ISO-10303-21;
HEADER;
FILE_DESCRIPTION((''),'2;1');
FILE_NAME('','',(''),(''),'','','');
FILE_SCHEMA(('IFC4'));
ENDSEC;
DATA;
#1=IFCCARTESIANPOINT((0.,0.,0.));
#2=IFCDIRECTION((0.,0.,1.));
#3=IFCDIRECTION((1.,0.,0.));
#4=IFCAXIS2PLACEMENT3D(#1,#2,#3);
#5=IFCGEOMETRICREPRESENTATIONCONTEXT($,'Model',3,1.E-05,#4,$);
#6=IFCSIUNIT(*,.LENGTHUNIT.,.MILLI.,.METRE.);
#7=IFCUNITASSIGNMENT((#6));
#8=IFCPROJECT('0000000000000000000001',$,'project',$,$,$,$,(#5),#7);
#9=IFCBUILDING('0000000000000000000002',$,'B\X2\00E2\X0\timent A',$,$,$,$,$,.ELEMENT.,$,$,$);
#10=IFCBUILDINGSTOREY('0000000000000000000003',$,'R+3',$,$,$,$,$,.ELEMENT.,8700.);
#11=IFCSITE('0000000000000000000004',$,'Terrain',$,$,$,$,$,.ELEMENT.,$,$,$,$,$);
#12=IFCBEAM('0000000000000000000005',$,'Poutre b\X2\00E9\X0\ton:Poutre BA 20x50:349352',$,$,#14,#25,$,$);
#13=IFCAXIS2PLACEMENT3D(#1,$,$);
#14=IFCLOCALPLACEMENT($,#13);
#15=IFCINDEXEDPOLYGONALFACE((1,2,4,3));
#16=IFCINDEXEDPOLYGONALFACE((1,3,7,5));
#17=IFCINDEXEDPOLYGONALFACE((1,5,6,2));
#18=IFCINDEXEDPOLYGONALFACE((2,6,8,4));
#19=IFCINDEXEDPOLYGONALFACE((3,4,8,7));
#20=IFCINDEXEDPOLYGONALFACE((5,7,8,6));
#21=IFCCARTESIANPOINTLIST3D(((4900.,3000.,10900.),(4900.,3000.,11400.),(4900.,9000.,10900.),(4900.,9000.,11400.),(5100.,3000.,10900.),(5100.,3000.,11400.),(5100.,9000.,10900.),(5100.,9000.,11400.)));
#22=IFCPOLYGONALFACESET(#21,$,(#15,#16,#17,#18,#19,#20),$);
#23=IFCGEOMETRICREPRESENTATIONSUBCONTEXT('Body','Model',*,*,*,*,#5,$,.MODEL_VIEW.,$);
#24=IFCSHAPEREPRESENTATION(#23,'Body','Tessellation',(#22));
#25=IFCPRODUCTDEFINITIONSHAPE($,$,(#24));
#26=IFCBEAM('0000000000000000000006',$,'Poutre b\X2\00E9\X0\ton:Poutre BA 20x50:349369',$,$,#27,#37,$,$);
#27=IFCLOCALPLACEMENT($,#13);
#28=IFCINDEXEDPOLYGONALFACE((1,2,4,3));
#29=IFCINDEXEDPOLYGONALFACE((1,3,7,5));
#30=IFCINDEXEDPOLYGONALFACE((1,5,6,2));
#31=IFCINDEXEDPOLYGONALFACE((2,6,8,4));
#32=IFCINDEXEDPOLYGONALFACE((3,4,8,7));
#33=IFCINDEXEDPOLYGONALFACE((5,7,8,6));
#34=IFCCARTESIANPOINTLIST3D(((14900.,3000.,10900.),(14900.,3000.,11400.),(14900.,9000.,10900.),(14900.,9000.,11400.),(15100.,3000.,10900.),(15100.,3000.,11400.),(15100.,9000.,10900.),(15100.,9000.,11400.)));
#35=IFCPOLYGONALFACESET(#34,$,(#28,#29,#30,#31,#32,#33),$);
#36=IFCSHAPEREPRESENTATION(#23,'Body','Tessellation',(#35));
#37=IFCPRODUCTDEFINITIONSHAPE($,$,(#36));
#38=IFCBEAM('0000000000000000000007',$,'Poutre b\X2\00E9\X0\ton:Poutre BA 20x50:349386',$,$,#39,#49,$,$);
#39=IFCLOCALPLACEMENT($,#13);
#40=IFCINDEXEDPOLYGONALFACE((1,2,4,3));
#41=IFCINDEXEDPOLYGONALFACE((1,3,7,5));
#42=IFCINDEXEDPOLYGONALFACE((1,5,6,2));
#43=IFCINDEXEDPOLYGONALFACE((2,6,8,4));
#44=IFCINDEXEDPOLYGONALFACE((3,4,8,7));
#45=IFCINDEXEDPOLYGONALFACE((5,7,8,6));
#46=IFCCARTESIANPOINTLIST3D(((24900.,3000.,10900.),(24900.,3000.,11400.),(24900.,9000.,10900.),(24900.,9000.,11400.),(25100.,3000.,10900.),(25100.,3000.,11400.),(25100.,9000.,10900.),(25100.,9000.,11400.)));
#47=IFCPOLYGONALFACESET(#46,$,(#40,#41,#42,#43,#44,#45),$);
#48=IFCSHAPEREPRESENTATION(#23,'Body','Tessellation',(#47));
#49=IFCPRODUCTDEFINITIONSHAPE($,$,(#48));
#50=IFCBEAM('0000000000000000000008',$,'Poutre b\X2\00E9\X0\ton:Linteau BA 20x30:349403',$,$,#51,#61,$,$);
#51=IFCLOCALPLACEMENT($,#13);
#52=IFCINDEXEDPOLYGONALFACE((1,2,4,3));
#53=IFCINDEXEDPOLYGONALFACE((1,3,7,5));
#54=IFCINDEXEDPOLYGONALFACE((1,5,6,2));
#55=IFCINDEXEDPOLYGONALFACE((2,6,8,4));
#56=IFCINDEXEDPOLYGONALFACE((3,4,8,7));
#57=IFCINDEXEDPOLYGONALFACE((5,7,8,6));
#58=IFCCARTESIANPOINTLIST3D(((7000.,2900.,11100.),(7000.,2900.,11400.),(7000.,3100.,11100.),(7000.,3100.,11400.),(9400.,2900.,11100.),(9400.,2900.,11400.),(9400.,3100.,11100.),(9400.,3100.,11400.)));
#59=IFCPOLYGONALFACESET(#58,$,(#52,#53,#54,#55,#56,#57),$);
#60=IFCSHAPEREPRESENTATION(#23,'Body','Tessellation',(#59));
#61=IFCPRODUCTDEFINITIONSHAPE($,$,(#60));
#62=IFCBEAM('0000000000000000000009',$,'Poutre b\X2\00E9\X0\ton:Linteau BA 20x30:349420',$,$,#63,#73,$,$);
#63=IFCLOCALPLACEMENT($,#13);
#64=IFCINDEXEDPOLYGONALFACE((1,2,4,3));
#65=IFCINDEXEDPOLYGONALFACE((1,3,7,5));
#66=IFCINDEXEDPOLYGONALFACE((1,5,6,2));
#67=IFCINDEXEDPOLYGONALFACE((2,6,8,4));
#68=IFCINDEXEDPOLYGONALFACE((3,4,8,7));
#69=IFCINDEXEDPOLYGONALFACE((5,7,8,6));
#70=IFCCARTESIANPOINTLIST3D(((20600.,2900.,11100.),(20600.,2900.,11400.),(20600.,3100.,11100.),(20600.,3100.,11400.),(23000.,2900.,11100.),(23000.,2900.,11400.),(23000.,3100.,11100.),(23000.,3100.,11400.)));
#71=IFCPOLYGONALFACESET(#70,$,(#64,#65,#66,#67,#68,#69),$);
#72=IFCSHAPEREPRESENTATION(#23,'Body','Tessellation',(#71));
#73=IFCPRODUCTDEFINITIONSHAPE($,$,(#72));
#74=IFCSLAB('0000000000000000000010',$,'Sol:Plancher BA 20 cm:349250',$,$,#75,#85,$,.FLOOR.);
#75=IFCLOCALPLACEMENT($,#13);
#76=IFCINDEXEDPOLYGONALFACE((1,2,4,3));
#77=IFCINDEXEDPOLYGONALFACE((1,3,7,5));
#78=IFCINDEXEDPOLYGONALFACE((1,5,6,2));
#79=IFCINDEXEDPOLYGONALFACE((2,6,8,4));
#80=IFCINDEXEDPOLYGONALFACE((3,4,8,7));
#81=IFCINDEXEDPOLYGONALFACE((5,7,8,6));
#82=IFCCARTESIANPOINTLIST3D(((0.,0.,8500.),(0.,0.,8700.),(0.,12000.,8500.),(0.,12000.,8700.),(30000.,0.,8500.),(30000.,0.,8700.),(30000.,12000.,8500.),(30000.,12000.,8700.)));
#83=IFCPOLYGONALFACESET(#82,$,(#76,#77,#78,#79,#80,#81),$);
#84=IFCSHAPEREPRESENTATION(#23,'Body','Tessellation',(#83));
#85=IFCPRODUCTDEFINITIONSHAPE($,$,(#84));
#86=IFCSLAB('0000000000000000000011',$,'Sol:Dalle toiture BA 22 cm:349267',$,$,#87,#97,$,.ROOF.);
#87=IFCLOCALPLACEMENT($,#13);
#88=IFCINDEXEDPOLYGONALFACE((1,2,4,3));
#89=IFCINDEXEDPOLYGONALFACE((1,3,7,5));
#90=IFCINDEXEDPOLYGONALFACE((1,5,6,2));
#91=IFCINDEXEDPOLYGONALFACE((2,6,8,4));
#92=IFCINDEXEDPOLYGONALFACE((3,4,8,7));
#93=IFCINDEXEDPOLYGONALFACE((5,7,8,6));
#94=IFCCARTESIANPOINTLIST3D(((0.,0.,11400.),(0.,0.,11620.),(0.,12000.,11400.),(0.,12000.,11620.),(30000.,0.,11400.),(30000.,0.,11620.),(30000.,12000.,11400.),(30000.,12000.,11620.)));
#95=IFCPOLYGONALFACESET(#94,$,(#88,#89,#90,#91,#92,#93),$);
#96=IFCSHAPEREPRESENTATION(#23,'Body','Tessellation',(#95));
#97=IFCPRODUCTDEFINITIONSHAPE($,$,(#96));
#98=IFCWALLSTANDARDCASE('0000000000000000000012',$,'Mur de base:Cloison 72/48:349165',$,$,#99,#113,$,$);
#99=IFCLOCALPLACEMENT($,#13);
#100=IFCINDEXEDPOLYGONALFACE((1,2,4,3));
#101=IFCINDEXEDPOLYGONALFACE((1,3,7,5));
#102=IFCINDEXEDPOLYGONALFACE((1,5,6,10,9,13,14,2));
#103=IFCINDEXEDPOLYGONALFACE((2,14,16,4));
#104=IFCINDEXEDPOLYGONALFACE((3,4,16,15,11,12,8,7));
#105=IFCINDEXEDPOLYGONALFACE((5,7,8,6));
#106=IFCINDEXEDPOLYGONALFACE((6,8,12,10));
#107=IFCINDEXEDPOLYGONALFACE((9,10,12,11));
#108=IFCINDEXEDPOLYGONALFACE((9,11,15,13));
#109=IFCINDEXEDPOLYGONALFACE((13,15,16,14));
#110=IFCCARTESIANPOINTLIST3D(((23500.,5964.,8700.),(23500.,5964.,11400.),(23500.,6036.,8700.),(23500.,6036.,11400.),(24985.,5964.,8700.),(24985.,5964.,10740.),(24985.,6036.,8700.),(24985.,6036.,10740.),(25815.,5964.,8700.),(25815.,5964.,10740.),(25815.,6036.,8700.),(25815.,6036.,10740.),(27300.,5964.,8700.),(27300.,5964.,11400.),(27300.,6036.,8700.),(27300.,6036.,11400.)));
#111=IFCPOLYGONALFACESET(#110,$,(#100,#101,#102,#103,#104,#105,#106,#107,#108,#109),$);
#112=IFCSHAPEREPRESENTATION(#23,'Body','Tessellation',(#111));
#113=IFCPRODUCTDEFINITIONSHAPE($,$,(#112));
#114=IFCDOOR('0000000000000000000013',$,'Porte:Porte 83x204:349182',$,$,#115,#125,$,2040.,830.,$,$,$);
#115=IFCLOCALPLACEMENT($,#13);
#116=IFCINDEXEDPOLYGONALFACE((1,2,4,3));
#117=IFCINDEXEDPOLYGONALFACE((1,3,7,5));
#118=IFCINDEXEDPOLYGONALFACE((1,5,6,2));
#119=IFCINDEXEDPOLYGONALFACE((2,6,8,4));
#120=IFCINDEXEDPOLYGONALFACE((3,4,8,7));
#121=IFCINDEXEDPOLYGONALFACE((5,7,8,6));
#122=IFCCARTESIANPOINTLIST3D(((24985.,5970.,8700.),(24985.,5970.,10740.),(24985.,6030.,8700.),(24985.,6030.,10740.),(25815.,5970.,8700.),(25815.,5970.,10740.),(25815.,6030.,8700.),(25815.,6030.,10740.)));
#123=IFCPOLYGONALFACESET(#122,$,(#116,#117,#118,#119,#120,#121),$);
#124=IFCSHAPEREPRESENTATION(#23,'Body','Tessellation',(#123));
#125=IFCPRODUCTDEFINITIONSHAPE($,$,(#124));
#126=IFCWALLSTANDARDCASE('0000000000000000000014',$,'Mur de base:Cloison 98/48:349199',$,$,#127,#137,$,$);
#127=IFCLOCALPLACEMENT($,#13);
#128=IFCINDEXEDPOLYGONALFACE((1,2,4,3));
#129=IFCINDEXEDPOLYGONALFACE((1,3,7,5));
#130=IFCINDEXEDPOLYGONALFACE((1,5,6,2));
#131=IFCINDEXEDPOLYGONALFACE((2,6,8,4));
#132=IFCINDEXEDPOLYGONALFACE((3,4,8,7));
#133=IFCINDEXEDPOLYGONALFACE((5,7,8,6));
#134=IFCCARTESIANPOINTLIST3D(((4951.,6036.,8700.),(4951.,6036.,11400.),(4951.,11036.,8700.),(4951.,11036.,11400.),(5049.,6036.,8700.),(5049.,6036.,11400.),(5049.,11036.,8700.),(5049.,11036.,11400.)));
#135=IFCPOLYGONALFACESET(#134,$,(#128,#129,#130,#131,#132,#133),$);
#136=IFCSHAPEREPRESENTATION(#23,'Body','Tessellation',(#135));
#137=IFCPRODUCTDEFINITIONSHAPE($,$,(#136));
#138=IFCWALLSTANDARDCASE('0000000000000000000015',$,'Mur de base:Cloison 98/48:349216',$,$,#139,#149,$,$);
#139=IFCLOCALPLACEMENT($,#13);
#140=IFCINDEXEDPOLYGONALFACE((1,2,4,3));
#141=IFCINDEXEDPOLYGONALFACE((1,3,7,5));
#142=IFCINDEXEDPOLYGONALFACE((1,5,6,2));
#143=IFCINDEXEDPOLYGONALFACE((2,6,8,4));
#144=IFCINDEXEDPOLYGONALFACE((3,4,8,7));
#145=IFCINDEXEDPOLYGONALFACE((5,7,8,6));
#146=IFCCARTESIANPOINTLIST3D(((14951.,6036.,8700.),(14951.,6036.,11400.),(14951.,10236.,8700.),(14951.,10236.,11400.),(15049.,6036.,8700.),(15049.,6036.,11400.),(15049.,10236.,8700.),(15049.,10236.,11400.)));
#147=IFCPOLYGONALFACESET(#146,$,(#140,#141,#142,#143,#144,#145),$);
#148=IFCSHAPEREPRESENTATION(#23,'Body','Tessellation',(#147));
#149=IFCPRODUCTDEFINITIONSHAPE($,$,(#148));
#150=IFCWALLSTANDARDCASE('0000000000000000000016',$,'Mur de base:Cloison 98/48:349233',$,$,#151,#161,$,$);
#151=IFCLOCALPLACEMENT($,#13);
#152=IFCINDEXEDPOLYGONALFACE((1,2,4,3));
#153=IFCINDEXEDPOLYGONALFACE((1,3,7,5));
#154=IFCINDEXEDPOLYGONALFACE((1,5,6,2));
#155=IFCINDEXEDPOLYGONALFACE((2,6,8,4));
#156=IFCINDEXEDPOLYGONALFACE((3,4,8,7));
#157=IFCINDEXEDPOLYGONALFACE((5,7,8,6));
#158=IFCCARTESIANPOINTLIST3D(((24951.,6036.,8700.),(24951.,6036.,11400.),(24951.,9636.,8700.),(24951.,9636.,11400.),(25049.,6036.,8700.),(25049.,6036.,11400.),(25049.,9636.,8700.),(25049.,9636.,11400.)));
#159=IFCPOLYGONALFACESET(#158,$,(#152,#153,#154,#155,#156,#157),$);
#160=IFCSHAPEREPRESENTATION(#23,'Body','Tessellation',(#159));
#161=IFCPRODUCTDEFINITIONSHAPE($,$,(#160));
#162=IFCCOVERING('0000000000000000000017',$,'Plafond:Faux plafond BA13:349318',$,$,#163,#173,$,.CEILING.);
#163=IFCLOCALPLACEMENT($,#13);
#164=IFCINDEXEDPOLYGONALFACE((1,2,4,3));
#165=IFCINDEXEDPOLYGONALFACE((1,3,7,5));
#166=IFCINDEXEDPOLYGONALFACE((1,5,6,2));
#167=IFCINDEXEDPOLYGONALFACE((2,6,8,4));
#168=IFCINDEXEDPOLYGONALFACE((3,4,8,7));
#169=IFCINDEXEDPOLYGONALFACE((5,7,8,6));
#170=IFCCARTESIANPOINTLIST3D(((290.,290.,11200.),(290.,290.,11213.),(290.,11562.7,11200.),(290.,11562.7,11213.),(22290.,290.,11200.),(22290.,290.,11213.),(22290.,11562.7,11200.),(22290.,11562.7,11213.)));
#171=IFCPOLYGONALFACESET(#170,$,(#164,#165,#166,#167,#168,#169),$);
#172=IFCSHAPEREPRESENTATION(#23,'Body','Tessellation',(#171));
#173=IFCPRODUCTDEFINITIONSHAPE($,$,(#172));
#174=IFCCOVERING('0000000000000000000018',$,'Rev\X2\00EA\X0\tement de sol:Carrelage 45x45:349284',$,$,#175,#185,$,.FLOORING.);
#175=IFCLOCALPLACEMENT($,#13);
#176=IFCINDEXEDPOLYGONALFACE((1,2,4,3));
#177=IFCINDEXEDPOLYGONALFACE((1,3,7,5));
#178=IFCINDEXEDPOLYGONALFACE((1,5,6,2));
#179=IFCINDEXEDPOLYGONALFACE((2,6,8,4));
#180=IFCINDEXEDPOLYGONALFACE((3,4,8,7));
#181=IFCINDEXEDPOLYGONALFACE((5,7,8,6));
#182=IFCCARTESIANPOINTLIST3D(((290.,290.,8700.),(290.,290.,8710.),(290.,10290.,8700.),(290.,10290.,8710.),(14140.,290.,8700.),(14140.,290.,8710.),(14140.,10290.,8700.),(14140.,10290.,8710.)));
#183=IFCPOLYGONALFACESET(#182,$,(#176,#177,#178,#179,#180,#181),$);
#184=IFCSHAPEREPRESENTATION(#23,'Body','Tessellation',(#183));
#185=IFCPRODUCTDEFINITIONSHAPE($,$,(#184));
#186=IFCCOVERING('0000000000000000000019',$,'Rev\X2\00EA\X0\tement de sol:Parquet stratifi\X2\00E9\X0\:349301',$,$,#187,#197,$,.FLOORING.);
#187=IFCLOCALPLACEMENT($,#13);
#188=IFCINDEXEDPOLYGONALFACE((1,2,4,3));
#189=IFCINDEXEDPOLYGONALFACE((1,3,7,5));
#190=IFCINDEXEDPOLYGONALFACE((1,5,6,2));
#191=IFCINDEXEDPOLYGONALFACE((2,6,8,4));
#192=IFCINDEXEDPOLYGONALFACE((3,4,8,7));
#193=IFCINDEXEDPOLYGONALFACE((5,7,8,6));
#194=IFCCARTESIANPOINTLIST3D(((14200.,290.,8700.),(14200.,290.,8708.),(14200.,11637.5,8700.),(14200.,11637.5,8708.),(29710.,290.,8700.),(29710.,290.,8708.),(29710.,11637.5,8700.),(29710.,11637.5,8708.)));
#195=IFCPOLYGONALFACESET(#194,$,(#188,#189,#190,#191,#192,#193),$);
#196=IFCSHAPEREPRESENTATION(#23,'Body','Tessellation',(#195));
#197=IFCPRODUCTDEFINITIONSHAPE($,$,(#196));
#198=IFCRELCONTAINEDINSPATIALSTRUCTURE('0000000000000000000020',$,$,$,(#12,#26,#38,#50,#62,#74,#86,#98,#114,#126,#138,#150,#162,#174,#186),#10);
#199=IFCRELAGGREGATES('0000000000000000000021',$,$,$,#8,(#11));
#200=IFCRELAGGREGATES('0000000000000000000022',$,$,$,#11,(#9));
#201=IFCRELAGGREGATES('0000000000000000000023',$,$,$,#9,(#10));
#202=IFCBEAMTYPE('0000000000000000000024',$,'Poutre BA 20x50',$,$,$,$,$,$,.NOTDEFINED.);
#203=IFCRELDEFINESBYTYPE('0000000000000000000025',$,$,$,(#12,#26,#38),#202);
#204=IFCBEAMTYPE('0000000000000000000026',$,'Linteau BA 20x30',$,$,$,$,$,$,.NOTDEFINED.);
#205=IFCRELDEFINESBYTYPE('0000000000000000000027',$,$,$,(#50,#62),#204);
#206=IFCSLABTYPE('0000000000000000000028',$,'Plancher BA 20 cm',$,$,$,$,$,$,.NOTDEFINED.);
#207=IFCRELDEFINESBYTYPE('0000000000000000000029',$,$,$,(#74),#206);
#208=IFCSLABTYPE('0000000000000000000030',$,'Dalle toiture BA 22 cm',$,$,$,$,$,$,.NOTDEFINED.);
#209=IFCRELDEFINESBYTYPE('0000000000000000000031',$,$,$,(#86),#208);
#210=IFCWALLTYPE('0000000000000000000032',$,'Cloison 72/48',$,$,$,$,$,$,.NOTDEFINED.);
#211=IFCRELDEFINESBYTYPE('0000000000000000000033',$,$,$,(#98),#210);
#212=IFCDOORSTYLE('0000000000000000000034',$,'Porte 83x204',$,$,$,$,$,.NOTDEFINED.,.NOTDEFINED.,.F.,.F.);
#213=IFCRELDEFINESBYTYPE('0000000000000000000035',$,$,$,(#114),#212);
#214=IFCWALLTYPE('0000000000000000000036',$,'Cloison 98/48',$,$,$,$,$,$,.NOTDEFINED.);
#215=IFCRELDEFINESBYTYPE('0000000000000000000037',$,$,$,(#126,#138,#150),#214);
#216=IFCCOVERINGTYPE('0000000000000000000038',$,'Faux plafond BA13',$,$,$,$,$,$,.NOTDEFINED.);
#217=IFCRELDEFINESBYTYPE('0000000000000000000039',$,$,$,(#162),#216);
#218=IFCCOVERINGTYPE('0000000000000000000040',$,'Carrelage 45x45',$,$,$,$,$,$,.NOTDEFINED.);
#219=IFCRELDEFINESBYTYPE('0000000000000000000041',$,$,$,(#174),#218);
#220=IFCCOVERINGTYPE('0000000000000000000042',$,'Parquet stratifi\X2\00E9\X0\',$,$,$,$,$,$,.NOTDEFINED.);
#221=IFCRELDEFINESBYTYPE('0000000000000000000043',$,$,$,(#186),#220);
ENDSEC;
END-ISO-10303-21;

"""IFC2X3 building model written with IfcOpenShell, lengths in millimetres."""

from ifc_helpers import new_model, si_unit, frame, frame_2d, origin_with_axes, place, context, subcontext, project, spatial, rectangle, extrude, type_object, element, fill, save


model = new_model("IFC2X3")

# Units and contexts
model_context = context("Model", 3, precision=1e-05, world=origin_with_axes())
body_context = subcontext(model_context, "Body", "Model", "MODEL_VIEW")
ifc_project = project(units=[si_unit("LENGTHUNIT", "METRE", prefix="MILLI")], contexts=[model_context])

# Site, building, storey
site = spatial("IfcSite", under=ifc_project, Name="Terrain", CompositionType="ELEMENT")
building = spatial("IfcBuilding", under=site, Name="Bâtiment A", CompositionType="ELEMENT")
storey = spatial("IfcBuildingStorey", under=building, Name="R+3", CompositionType="ELEMENT", Elevation=8700.0)

# Beams
beam_type_1 = type_object("IfcBeamType", Name="Poutre BA 20x50", PredefinedType="NOTDEFINED")
beam_1_placement = place(None, origin_with_axes())
element("IfcBeam", 1, at=beam_1_placement, inside=storey, type_object=beam_type_1, Name="Poutre béton:Poutre BA 20x50:349352", context=body_context, shape_type="SweptSolid", body=[
    extrude(rectangle(XDim=200.0, YDim=6000.0, at=frame_2d((5000.0, 6000.0))), frame((0.0, 0.0, 10900.0), z_axis=(0.0, 0.0, 1.0), x_axis=(1.0, 0.0, 0.0)), (0.0, 0.0, 1.0), 500.0),
])
beam_2_placement = place(None, origin_with_axes())
element("IfcBeam", 2, at=beam_2_placement, inside=storey, type_object=beam_type_1, Name="Poutre béton:Poutre BA 20x50:349369", context=body_context, shape_type="SweptSolid", body=[
    extrude(rectangle(XDim=200.0, YDim=6000.0, at=frame_2d((15000.0, 6000.0))), frame((0.0, 0.0, 10900.0), z_axis=(0.0, 0.0, 1.0), x_axis=(1.0, 0.0, 0.0)), (0.0, 0.0, 1.0), 500.0),
])
beam_3_placement = place(None, origin_with_axes())
element("IfcBeam", 3, at=beam_3_placement, inside=storey, type_object=beam_type_1, Name="Poutre béton:Poutre BA 20x50:349386", context=body_context, shape_type="SweptSolid", body=[
    extrude(rectangle(XDim=200.0, YDim=6000.0, at=frame_2d((25000.0, 6000.0))), frame((0.0, 0.0, 10900.0), z_axis=(0.0, 0.0, 1.0), x_axis=(1.0, 0.0, 0.0)), (0.0, 0.0, 1.0), 500.0),
])
beam_type_2 = type_object("IfcBeamType", Name="Linteau BA 20x30", PredefinedType="NOTDEFINED")
beam_4_placement = place(None, origin_with_axes())
element("IfcBeam", 4, at=beam_4_placement, inside=storey, type_object=beam_type_2, Name="Poutre béton:Linteau BA 20x30:349403", context=body_context, shape_type="SweptSolid", body=[
    extrude(rectangle(XDim=2400.0, YDim=200.0, at=frame_2d((8200.0, 3000.0))), frame((0.0, 0.0, 11100.0), z_axis=(0.0, 0.0, 1.0), x_axis=(1.0, 0.0, 0.0)), (0.0, 0.0, 1.0), 300.0),
])
beam_5_placement = place(None, origin_with_axes())
element("IfcBeam", 5, at=beam_5_placement, inside=storey, type_object=beam_type_2, Name="Poutre béton:Linteau BA 20x30:349420", context=body_context, shape_type="SweptSolid", body=[
    extrude(rectangle(XDim=2400.0, YDim=200.0, at=frame_2d((21800.0, 3000.0))), frame((0.0, 0.0, 11100.0), z_axis=(0.0, 0.0, 1.0), x_axis=(1.0, 0.0, 0.0)), (0.0, 0.0, 1.0), 300.0),
])

# Slabs
slab_type_1 = type_object("IfcSlabType", Name="Plancher BA 20 cm", PredefinedType="NOTDEFINED")
slab_1_placement = place(None, origin_with_axes())
element("IfcSlab", 6, at=slab_1_placement, inside=storey, type_object=slab_type_1, Name="Sol:Plancher BA 20 cm:349250", PredefinedType="FLOOR", context=body_context, shape_type="SweptSolid", body=[
    extrude(rectangle(XDim=30000.0, YDim=12000.0, at=frame_2d((15000.0, 6000.0))), frame((0.0, 0.0, 8500.0), z_axis=(0.0, 0.0, 1.0), x_axis=(1.0, 0.0, 0.0)), (0.0, 0.0, 1.0), 200.0),
])
slab_type_2 = type_object("IfcSlabType", Name="Dalle toiture BA 22 cm", PredefinedType="NOTDEFINED")
slab_2_placement = place(None, origin_with_axes())
element("IfcSlab", 7, at=slab_2_placement, inside=storey, type_object=slab_type_2, Name="Sol:Dalle toiture BA 22 cm:349267", PredefinedType="ROOF", context=body_context, shape_type="SweptSolid", body=[
    extrude(rectangle(XDim=30000.0, YDim=12000.0, at=frame_2d((15000.0, 6000.0))), frame((0.0, 0.0, 11400.0), z_axis=(0.0, 0.0, 1.0), x_axis=(1.0, 0.0, 0.0)), (0.0, 0.0, 1.0), 220.0),
])

# Wall, opening, door
wall_type_1 = type_object("IfcWallType", Name="Cloison 72/48", PredefinedType="NOTDEFINED")
wall_1_placement = place(None, origin_with_axes())
wall_1 = element("IfcWallStandardCase", 8, at=wall_1_placement, inside=storey, type_object=wall_type_1, Name="Mur de base:Cloison 72/48:349165", context=body_context, shape_type="SweptSolid", body=[
    extrude(rectangle(XDim=3800.0, YDim=72.0, at=frame_2d((25400.0, 6000.0))), frame((0.0, 0.0, 8700.0), z_axis=(0.0, 0.0, 1.0), x_axis=(1.0, 0.0, 0.0)), (0.0, 0.0, 1.0), 2700.0),
])
opening_placement = place(None, origin_with_axes())
opening = element("IfcOpeningElement", 9, at=opening_placement, cuts=wall_1, context=body_context, shape_type="SweptSolid", body=[
    extrude(rectangle(XDim=830.0, YDim=192.0, at=frame_2d((25400.0, 6000.0))), frame((0.0, 0.0, 8700.0), z_axis=(0.0, 0.0, 1.0), x_axis=(1.0, 0.0, 0.0)), (0.0, 0.0, 1.0), 2040.0),
])
door_style = type_object("IfcDoorStyle", Name="Porte 83x204", ConstructionType="NOTDEFINED", OperationType="NOTDEFINED", ParameterTakesPrecedence=False, Sizeable=False)
door_placement = place(None, origin_with_axes())
door = element("IfcDoor", 10, at=door_placement, inside=storey, type_object=door_style, Name="Porte:Porte 83x204:349182", OverallHeight=2040.0, OverallWidth=830.0, context=body_context, shape_type="SweptSolid", body=[
    extrude(rectangle(XDim=830.0, YDim=60.0, at=frame_2d((25400.0, 6000.0))), frame((0.0, 0.0, 8700.0), z_axis=(0.0, 0.0, 1.0), x_axis=(1.0, 0.0, 0.0)), (0.0, 0.0, 1.0), 2040.0),
])
fill(opening, door)

# Walls
wall_type_2 = type_object("IfcWallType", Name="Cloison 98/48", PredefinedType="NOTDEFINED")
wall_2_placement = place(None, origin_with_axes())
element("IfcWallStandardCase", 11, at=wall_2_placement, inside=storey, type_object=wall_type_2, Name="Mur de base:Cloison 98/48:349199", context=body_context, shape_type="SweptSolid", body=[
    extrude(rectangle(XDim=98.0, YDim=5000.0, at=frame_2d((5000.0, 8536.0))), frame((0.0, 0.0, 8700.0), z_axis=(0.0, 0.0, 1.0), x_axis=(1.0, 0.0, 0.0)), (0.0, 0.0, 1.0), 2700.0),
])
wall_3_placement = place(None, origin_with_axes())
element("IfcWallStandardCase", 12, at=wall_3_placement, inside=storey, type_object=wall_type_2, Name="Mur de base:Cloison 98/48:349216", context=body_context, shape_type="SweptSolid", body=[
    extrude(rectangle(XDim=98.0, YDim=4200.0, at=frame_2d((15000.0, 8136.0))), frame((0.0, 0.0, 8700.0), z_axis=(0.0, 0.0, 1.0), x_axis=(1.0, 0.0, 0.0)), (0.0, 0.0, 1.0), 2700.0),
])
wall_4_placement = place(None, origin_with_axes())
element("IfcWallStandardCase", 13, at=wall_4_placement, inside=storey, type_object=wall_type_2, Name="Mur de base:Cloison 98/48:349233", context=body_context, shape_type="SweptSolid", body=[
    extrude(rectangle(XDim=98.0, YDim=3600.0, at=frame_2d((25000.0, 7836.0))), frame((0.0, 0.0, 8700.0), z_axis=(0.0, 0.0, 1.0), x_axis=(1.0, 0.0, 0.0)), (0.0, 0.0, 1.0), 2700.0),
])

# Coverings
covering_type_1 = type_object("IfcCoveringType", Name="Faux plafond BA13", PredefinedType="NOTDEFINED")
covering_1_placement = place(None, origin_with_axes())
element("IfcCovering", 14, at=covering_1_placement, inside=storey, type_object=covering_type_1, Name="Plafond:Faux plafond BA13:349318", PredefinedType="CEILING", context=body_context, shape_type="SweptSolid", body=[
    extrude(rectangle(XDim=22000.0, YDim=11272.7, at=frame_2d((11290.0, 5926.4))), frame((0.0, 0.0, 11200.0), z_axis=(0.0, 0.0, 1.0), x_axis=(1.0, 0.0, 0.0)), (0.0, 0.0, 1.0), 13.0),
])
covering_type_2 = type_object("IfcCoveringType", Name="Carrelage 45x45", PredefinedType="NOTDEFINED")
covering_2_placement = place(None, origin_with_axes())
element("IfcCovering", 15, at=covering_2_placement, inside=storey, type_object=covering_type_2, Name="Revêtement de sol:Carrelage 45x45:349284", PredefinedType="FLOORING", context=body_context, shape_type="SweptSolid", body=[
    extrude(rectangle(XDim=13850.0, YDim=10000.0, at=frame_2d((7215.0, 5290.0))), frame((0.0, 0.0, 8700.0), z_axis=(0.0, 0.0, 1.0), x_axis=(1.0, 0.0, 0.0)), (0.0, 0.0, 1.0), 10.0),
])
covering_type_3 = type_object("IfcCoveringType", Name="Parquet stratifié", PredefinedType="NOTDEFINED")
covering_3_placement = place(None, origin_with_axes())
element("IfcCovering", 16, at=covering_3_placement, inside=storey, type_object=covering_type_3, Name="Revêtement de sol:Parquet stratifié:349301", PredefinedType="FLOORING", context=body_context, shape_type="SweptSolid", body=[
    extrude(rectangle(XDim=15510.0, YDim=11347.5, at=frame_2d((21955.0, 5963.8))), frame((0.0, 0.0, 8700.0), z_axis=(0.0, 0.0, 1.0), x_axis=(1.0, 0.0, 0.0)), (0.0, 0.0, 1.0), 8.0),
])

save(model, "model.ifc")
